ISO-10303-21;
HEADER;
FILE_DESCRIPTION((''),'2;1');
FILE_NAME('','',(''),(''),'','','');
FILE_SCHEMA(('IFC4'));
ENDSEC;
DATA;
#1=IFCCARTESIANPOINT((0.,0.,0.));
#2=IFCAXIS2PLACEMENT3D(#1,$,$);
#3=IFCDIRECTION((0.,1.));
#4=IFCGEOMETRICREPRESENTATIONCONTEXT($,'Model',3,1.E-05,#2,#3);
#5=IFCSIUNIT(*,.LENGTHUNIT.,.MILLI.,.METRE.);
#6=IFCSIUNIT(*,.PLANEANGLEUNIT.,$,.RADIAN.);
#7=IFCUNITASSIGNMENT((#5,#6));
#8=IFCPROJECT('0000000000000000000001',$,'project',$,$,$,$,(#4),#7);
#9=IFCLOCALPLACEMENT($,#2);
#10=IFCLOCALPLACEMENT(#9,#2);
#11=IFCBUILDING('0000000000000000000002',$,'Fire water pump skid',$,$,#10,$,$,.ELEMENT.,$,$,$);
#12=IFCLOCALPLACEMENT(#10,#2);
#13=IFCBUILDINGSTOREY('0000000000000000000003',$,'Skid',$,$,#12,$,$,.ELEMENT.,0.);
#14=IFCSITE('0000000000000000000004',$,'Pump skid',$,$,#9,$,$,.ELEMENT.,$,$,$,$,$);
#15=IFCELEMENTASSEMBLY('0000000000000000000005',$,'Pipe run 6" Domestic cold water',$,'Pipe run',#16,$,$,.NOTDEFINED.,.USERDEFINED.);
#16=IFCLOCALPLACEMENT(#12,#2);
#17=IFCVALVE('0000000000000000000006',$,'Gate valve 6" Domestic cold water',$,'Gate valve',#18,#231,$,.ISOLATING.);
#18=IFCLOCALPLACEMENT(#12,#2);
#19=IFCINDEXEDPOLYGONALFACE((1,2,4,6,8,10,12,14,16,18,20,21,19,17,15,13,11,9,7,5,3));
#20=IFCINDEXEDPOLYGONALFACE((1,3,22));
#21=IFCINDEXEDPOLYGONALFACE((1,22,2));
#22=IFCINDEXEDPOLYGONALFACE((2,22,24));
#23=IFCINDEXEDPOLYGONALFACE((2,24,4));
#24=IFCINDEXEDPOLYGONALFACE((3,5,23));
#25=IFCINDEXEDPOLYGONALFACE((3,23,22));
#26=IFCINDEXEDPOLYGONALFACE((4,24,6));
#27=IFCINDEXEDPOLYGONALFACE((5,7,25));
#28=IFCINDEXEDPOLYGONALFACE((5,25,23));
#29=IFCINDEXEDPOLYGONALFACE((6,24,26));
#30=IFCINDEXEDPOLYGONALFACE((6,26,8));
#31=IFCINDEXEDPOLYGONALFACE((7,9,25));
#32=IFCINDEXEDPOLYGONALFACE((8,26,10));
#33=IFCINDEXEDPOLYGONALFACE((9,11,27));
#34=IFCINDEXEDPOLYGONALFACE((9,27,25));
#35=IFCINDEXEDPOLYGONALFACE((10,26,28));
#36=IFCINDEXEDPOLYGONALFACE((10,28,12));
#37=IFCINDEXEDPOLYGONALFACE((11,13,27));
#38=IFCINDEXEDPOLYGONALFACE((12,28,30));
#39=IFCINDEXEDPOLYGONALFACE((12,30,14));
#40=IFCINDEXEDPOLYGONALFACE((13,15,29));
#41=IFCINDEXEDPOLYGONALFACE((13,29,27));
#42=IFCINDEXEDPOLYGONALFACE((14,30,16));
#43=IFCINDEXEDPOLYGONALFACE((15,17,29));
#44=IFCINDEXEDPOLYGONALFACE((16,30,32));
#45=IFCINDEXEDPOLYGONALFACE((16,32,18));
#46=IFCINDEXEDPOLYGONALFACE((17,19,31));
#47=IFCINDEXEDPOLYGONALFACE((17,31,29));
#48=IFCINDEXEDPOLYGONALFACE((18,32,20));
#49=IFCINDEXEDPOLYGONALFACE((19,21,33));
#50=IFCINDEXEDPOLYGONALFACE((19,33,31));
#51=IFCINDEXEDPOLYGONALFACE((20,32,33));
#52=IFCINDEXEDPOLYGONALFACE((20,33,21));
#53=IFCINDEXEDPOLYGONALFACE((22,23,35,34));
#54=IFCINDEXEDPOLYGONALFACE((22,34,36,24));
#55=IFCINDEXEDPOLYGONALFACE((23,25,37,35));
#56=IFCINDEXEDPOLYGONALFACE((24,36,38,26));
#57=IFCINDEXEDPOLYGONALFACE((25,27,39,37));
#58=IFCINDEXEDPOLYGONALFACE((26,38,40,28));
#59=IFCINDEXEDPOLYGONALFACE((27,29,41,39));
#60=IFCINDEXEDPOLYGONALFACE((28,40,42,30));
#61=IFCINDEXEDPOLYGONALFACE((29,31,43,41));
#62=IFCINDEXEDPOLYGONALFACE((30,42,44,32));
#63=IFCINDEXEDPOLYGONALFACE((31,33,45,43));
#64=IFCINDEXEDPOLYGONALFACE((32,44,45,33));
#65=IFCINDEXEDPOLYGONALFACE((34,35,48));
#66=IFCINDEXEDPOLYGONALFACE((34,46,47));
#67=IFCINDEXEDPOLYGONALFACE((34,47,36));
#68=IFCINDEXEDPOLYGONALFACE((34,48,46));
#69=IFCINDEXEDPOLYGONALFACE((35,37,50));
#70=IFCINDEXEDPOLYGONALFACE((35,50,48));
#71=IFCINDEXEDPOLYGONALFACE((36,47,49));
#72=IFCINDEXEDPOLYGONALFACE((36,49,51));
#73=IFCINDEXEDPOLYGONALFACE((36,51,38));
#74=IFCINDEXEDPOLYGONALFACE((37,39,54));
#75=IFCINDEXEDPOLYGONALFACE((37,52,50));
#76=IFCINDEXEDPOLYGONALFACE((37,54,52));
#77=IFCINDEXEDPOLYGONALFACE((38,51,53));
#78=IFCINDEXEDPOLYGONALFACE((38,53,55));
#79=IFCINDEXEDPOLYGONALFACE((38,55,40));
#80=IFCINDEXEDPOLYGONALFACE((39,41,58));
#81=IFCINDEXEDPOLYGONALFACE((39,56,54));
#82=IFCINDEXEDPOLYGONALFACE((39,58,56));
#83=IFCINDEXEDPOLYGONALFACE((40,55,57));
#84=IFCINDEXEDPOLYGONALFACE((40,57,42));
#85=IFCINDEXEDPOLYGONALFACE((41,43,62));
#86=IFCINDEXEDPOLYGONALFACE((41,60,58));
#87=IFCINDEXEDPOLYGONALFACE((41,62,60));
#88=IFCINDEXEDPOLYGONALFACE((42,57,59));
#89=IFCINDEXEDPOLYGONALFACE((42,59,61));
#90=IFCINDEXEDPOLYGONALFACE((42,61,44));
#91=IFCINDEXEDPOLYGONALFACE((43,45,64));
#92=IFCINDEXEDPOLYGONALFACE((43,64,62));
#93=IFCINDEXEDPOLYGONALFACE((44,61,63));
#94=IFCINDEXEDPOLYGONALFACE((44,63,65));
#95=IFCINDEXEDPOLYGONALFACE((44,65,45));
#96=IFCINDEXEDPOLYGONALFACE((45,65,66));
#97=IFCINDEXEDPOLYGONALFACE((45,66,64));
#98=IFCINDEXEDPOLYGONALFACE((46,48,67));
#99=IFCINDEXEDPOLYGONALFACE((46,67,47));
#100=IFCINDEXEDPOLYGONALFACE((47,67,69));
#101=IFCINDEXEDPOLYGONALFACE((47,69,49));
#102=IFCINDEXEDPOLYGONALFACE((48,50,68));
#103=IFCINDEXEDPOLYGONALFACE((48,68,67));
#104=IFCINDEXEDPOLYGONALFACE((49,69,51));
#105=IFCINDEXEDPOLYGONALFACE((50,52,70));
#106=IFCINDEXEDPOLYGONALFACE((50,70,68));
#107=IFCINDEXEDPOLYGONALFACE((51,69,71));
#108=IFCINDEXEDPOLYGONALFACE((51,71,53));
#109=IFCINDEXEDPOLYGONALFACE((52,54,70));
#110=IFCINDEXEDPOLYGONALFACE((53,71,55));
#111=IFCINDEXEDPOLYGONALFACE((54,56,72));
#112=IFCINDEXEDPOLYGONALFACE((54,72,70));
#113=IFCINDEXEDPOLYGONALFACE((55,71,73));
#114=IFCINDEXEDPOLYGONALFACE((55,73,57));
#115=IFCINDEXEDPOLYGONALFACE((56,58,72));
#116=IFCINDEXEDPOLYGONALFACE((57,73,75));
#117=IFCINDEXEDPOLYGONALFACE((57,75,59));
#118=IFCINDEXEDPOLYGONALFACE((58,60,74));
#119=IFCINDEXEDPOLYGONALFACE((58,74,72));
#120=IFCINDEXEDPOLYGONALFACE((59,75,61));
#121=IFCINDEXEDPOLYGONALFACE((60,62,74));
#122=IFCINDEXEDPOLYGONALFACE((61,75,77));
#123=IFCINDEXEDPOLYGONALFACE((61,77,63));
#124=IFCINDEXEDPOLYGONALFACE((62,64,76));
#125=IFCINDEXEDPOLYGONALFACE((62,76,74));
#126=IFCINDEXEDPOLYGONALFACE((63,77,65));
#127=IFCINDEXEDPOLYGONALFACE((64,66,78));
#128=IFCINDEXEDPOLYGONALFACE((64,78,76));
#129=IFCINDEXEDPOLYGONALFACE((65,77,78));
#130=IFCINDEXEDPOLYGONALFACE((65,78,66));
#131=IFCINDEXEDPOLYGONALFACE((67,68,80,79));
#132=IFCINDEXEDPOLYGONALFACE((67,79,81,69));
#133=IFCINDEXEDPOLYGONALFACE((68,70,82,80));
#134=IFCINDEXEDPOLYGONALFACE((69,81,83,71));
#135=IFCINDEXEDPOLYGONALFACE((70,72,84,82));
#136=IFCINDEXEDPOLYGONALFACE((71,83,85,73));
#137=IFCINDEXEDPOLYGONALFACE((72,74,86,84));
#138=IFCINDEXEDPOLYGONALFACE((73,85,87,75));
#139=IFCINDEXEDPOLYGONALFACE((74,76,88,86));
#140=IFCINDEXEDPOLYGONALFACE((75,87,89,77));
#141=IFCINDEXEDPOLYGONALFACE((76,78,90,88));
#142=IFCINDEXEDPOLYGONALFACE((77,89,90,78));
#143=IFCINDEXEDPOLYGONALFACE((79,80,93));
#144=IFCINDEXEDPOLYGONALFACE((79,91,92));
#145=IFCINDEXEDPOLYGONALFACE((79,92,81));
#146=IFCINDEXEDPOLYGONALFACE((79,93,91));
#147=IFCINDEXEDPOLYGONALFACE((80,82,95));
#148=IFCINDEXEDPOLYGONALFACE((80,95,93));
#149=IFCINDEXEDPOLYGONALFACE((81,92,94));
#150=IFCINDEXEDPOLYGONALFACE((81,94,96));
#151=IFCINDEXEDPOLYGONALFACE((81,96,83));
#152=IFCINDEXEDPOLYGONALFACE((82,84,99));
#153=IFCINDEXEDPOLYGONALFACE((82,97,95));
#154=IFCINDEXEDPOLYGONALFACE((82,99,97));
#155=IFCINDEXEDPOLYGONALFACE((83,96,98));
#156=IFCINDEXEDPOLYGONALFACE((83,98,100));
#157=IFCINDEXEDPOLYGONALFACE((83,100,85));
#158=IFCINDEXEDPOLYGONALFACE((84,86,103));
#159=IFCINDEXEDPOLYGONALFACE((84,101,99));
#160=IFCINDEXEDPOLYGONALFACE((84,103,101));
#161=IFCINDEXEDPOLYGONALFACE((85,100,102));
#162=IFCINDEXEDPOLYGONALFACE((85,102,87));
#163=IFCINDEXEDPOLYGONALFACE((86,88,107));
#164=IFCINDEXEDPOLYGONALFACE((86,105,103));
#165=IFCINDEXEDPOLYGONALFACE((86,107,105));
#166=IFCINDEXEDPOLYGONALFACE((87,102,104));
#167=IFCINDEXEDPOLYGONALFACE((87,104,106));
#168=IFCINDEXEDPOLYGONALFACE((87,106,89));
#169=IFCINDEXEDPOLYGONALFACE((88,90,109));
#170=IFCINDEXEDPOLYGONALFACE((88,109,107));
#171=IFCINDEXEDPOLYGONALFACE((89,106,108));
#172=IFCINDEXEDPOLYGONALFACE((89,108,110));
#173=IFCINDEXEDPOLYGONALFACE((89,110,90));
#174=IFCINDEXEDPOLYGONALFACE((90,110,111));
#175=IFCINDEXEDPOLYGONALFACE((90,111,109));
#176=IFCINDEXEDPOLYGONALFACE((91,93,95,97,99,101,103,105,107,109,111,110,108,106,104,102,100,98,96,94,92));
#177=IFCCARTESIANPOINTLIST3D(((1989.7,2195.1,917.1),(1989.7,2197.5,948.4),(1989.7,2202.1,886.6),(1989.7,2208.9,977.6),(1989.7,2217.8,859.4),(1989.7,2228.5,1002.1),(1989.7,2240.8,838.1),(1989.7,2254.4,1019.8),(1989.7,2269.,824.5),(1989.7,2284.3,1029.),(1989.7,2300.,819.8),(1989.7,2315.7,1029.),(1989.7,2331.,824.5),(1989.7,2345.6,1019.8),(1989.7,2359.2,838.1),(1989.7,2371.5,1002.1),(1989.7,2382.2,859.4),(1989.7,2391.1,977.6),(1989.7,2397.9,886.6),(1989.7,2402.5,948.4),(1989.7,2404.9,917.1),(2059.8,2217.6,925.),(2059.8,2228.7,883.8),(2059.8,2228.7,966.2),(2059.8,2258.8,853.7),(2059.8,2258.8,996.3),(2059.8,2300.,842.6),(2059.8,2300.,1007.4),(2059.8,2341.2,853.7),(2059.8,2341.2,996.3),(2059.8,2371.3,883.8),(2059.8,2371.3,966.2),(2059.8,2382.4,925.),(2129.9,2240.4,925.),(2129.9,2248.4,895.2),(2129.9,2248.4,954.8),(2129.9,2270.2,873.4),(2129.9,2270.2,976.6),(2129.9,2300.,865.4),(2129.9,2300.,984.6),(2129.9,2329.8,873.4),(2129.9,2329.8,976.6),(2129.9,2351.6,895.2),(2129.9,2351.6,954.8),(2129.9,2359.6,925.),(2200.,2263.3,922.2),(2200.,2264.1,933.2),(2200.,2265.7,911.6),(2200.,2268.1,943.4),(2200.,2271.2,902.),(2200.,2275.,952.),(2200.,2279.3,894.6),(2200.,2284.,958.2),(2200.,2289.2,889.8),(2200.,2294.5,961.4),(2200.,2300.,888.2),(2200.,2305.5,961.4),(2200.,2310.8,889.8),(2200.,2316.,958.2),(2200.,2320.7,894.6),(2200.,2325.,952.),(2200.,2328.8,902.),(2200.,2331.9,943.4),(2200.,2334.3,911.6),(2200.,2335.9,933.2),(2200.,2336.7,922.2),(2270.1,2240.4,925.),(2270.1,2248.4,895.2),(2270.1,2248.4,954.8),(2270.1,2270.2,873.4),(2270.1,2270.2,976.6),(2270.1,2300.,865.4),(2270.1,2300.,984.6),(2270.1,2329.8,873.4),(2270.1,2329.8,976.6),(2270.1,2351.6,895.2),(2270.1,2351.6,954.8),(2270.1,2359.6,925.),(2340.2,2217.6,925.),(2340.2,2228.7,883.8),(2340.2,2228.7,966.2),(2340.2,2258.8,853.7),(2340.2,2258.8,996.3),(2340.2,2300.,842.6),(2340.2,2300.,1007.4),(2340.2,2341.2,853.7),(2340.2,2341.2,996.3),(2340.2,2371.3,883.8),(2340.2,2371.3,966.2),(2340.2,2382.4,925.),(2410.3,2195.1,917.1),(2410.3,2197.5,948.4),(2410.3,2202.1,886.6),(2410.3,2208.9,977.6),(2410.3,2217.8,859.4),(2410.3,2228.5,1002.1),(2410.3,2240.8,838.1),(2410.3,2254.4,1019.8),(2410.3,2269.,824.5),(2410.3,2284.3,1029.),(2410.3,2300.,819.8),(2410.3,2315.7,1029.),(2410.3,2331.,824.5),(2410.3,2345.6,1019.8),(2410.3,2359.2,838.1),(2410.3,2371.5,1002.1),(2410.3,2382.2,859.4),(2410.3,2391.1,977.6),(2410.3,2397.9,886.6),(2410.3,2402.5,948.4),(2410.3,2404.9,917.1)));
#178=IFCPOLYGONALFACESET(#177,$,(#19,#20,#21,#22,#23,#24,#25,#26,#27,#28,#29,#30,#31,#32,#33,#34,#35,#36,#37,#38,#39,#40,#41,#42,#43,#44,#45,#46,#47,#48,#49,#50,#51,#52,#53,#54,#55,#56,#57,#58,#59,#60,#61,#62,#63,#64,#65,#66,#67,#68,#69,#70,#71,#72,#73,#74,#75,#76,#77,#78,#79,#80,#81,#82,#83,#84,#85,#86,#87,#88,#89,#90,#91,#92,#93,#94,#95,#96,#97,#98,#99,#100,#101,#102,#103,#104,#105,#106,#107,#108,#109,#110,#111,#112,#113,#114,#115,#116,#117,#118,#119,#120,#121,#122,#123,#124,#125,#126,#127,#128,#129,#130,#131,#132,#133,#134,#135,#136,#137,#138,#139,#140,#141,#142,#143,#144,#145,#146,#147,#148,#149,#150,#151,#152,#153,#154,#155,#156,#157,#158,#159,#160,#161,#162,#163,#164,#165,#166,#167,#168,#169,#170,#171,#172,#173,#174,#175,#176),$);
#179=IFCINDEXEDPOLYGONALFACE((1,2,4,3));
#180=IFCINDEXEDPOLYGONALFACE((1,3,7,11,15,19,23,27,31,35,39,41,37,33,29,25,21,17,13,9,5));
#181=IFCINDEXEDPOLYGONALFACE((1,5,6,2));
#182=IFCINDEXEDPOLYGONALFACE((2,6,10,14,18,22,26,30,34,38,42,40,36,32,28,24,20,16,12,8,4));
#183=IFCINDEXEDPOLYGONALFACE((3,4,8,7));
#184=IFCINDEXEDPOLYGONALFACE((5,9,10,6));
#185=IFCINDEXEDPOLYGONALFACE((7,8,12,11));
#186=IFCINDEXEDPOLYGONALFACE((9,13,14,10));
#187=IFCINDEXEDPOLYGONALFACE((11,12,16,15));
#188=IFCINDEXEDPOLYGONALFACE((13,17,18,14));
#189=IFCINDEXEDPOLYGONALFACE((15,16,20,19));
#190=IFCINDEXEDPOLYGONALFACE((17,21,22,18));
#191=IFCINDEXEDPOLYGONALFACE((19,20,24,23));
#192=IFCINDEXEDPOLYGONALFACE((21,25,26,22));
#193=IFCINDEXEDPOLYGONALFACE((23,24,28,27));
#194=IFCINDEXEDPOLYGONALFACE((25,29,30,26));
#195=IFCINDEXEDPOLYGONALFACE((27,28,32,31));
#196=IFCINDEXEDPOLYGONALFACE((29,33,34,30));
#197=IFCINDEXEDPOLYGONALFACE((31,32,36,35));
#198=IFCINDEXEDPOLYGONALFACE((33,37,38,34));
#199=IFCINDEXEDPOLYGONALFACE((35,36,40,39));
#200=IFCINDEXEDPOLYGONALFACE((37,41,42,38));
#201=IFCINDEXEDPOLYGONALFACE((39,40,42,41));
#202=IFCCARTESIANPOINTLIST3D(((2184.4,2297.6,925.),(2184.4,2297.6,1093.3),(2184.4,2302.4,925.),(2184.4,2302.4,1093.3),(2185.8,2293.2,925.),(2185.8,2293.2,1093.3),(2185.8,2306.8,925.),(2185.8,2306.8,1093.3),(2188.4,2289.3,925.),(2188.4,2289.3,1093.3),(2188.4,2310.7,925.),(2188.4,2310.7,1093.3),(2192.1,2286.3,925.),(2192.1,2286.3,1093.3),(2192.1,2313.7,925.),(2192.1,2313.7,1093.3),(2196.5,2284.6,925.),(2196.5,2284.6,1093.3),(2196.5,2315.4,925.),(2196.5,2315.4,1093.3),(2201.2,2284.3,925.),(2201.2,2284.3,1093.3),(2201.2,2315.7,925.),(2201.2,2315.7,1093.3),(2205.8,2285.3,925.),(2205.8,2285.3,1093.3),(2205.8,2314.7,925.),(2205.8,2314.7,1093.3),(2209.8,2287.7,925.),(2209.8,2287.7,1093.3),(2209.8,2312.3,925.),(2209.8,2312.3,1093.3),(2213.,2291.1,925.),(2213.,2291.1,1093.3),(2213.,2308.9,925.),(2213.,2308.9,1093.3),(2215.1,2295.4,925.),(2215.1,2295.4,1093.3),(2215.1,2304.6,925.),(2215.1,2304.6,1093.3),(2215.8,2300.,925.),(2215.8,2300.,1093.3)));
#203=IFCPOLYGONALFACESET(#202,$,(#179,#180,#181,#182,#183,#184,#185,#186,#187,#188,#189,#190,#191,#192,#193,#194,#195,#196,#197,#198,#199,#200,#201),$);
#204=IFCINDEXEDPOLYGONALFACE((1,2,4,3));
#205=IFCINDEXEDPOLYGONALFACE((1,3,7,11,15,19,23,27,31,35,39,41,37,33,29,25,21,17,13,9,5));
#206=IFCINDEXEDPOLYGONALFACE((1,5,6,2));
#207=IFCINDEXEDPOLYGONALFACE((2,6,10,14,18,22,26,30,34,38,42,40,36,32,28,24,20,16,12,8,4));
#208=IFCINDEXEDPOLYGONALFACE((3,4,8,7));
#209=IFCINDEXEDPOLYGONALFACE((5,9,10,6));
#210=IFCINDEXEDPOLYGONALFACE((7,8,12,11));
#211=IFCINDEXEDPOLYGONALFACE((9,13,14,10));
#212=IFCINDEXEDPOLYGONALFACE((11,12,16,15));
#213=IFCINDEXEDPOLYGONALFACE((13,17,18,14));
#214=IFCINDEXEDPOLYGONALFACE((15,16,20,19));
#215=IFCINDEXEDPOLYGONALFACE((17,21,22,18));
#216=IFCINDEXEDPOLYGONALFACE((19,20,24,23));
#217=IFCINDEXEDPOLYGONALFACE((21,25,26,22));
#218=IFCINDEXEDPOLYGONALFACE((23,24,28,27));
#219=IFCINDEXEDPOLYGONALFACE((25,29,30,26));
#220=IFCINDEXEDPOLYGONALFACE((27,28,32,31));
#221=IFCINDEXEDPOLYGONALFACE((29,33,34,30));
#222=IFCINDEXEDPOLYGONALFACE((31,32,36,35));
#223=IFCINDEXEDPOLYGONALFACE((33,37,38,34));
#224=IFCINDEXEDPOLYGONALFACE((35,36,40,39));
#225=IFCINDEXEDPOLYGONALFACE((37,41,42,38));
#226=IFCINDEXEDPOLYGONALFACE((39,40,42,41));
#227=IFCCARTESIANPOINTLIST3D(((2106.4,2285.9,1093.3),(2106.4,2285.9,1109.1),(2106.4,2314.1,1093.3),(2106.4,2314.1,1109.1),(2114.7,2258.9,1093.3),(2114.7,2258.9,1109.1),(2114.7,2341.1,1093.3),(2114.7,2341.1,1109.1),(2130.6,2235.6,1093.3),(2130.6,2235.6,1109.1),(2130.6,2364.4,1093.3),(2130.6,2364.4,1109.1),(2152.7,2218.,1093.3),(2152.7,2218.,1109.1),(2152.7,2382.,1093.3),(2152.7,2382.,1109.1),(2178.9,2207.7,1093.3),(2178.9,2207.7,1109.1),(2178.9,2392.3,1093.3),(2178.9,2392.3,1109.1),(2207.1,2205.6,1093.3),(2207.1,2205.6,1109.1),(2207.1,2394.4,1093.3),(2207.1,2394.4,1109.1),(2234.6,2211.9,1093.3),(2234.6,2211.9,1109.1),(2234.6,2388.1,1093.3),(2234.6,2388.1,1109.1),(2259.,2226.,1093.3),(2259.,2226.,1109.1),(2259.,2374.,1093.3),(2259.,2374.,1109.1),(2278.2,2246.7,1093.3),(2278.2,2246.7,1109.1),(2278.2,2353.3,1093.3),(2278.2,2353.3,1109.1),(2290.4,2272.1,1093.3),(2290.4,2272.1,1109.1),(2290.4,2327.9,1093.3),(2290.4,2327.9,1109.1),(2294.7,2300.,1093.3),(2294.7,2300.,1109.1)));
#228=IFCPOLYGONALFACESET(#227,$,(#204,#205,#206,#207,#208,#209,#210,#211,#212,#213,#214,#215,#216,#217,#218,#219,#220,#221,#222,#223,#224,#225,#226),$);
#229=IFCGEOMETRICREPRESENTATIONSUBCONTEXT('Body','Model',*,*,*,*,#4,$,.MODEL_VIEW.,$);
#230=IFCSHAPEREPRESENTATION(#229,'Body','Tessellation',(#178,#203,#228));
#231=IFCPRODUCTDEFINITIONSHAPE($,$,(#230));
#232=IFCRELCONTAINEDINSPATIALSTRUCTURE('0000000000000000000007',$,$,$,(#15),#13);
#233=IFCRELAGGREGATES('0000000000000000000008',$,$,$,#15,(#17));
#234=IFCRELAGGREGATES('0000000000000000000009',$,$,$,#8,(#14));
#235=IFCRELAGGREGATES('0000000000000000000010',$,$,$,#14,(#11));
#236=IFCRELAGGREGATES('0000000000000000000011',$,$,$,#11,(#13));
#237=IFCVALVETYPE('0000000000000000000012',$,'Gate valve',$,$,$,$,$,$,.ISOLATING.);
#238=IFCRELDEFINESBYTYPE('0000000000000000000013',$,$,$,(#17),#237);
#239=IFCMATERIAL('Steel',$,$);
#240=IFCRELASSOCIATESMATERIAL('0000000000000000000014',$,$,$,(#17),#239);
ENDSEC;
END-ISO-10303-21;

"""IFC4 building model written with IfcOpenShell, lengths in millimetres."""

from ifc_helpers import new_model, entity, si_unit, direction, frame, origin, origin_with_axes, origin_2d, place, context, subcontext, project, spatial, circle, extrude, material, type_object, element, aggregate, save


model = new_model("IFC4")

# Units and contexts
model_context = context("Model", 3, precision=1e-05, world=origin(), true_north=direction((0.0, 1.0)))
body_context = subcontext(model_context, "Body", "Model", "MODEL_VIEW")
ifc_project = project(units=[si_unit("LENGTHUNIT", "METRE", prefix="MILLI"), si_unit("PLANEANGLEUNIT", "RADIAN")], contexts=[model_context])

# Site, building, storey
site_placement = place(None, origin())
site = spatial("IfcSite", under=ifc_project, at=site_placement, Name="Pump skid", CompositionType="ELEMENT")
building_placement = place(site_placement, origin())
building = spatial("IfcBuilding", under=site, at=building_placement, Name="Fire water pump skid", CompositionType="ELEMENT")
storey_placement = place(building_placement, origin())
storey = spatial("IfcBuildingStorey", under=building, at=storey_placement, Name="Skid", CompositionType="ELEMENT", Elevation=0.0)

# Element assembly
assembly_1_placement = place(storey_placement, origin_with_axes())
assembly_1 = element("IfcElementAssembly", 1, at=assembly_1_placement, inside=storey, Name="Pipe run 6\" Domestic cold water", ObjectType="Pipe run", AssemblyPlace="NOTDEFINED", PredefinedType="USERDEFINED")
ifc_material = material(Name="Steel")

# Valve
valve_type_1 = type_object("IfcValveType", Name="Gate valve", PredefinedType="ISOLATING")
valve_1_placement = place(storey_placement, origin_with_axes())
cartesian_point_1 = entity("IfcCartesianPoint", [0.0, 0.0])
valve_1 = element("IfcValve", 2, at=valve_1_placement, type_object=valve_type_1, material=ifc_material, Name="Gate valve 6\" Domestic cold water", ObjectType="Gate valve", PredefinedType="ISOLATING", context=body_context, shape_type="SweptSolid", body=[
    entity("IfcRevolvedAreaSolid", entity("IfcArbitraryClosedProfileDef", "AREA", None, entity("IfcPolyline", [cartesian_point_1, entity("IfcCartesianPoint", [0.0, 105.2]), entity("IfcCartesianPoint", [210.3, 36.8]), entity("IfcCartesianPoint", [420.7, 105.2]), entity("IfcCartesianPoint", [420.7, 0.0]), cartesian_point_1])), entity("IfcAxis2Placement3D", entity("IfcCartesianPoint", [1989.7, 2300.0, 925.0]), entity("IfcDirection", [0.0, 1.0, 0.0]), entity("IfcDirection", [1.0, 0.0, 0.0])), entity("IfcAxis1Placement", entity("IfcCartesianPoint", [0.0, 0.0, 0.0]), entity("IfcDirection", [1.0, 0.0, 0.0])), 6.283185),
    extrude(circle(Radius=15.8, at=origin_2d()), frame((2200.0, 2300.0, 925.0), z_axis=(0.0, 0.0, 1.0), x_axis=(1.0, 0.0, 0.0)), (0.0, 0.0, 1.0), 168.3),
    extrude(circle(Radius=94.7, at=origin_2d()), frame((2200.0, 2300.0, 1093.3), z_axis=(0.0, 0.0, 1.0), x_axis=(1.0, 0.0, 0.0)), (0.0, 0.0, 1.0), 15.8),
])
aggregate(assembly_1, [valve_1])

save(model, "model.ifc")
